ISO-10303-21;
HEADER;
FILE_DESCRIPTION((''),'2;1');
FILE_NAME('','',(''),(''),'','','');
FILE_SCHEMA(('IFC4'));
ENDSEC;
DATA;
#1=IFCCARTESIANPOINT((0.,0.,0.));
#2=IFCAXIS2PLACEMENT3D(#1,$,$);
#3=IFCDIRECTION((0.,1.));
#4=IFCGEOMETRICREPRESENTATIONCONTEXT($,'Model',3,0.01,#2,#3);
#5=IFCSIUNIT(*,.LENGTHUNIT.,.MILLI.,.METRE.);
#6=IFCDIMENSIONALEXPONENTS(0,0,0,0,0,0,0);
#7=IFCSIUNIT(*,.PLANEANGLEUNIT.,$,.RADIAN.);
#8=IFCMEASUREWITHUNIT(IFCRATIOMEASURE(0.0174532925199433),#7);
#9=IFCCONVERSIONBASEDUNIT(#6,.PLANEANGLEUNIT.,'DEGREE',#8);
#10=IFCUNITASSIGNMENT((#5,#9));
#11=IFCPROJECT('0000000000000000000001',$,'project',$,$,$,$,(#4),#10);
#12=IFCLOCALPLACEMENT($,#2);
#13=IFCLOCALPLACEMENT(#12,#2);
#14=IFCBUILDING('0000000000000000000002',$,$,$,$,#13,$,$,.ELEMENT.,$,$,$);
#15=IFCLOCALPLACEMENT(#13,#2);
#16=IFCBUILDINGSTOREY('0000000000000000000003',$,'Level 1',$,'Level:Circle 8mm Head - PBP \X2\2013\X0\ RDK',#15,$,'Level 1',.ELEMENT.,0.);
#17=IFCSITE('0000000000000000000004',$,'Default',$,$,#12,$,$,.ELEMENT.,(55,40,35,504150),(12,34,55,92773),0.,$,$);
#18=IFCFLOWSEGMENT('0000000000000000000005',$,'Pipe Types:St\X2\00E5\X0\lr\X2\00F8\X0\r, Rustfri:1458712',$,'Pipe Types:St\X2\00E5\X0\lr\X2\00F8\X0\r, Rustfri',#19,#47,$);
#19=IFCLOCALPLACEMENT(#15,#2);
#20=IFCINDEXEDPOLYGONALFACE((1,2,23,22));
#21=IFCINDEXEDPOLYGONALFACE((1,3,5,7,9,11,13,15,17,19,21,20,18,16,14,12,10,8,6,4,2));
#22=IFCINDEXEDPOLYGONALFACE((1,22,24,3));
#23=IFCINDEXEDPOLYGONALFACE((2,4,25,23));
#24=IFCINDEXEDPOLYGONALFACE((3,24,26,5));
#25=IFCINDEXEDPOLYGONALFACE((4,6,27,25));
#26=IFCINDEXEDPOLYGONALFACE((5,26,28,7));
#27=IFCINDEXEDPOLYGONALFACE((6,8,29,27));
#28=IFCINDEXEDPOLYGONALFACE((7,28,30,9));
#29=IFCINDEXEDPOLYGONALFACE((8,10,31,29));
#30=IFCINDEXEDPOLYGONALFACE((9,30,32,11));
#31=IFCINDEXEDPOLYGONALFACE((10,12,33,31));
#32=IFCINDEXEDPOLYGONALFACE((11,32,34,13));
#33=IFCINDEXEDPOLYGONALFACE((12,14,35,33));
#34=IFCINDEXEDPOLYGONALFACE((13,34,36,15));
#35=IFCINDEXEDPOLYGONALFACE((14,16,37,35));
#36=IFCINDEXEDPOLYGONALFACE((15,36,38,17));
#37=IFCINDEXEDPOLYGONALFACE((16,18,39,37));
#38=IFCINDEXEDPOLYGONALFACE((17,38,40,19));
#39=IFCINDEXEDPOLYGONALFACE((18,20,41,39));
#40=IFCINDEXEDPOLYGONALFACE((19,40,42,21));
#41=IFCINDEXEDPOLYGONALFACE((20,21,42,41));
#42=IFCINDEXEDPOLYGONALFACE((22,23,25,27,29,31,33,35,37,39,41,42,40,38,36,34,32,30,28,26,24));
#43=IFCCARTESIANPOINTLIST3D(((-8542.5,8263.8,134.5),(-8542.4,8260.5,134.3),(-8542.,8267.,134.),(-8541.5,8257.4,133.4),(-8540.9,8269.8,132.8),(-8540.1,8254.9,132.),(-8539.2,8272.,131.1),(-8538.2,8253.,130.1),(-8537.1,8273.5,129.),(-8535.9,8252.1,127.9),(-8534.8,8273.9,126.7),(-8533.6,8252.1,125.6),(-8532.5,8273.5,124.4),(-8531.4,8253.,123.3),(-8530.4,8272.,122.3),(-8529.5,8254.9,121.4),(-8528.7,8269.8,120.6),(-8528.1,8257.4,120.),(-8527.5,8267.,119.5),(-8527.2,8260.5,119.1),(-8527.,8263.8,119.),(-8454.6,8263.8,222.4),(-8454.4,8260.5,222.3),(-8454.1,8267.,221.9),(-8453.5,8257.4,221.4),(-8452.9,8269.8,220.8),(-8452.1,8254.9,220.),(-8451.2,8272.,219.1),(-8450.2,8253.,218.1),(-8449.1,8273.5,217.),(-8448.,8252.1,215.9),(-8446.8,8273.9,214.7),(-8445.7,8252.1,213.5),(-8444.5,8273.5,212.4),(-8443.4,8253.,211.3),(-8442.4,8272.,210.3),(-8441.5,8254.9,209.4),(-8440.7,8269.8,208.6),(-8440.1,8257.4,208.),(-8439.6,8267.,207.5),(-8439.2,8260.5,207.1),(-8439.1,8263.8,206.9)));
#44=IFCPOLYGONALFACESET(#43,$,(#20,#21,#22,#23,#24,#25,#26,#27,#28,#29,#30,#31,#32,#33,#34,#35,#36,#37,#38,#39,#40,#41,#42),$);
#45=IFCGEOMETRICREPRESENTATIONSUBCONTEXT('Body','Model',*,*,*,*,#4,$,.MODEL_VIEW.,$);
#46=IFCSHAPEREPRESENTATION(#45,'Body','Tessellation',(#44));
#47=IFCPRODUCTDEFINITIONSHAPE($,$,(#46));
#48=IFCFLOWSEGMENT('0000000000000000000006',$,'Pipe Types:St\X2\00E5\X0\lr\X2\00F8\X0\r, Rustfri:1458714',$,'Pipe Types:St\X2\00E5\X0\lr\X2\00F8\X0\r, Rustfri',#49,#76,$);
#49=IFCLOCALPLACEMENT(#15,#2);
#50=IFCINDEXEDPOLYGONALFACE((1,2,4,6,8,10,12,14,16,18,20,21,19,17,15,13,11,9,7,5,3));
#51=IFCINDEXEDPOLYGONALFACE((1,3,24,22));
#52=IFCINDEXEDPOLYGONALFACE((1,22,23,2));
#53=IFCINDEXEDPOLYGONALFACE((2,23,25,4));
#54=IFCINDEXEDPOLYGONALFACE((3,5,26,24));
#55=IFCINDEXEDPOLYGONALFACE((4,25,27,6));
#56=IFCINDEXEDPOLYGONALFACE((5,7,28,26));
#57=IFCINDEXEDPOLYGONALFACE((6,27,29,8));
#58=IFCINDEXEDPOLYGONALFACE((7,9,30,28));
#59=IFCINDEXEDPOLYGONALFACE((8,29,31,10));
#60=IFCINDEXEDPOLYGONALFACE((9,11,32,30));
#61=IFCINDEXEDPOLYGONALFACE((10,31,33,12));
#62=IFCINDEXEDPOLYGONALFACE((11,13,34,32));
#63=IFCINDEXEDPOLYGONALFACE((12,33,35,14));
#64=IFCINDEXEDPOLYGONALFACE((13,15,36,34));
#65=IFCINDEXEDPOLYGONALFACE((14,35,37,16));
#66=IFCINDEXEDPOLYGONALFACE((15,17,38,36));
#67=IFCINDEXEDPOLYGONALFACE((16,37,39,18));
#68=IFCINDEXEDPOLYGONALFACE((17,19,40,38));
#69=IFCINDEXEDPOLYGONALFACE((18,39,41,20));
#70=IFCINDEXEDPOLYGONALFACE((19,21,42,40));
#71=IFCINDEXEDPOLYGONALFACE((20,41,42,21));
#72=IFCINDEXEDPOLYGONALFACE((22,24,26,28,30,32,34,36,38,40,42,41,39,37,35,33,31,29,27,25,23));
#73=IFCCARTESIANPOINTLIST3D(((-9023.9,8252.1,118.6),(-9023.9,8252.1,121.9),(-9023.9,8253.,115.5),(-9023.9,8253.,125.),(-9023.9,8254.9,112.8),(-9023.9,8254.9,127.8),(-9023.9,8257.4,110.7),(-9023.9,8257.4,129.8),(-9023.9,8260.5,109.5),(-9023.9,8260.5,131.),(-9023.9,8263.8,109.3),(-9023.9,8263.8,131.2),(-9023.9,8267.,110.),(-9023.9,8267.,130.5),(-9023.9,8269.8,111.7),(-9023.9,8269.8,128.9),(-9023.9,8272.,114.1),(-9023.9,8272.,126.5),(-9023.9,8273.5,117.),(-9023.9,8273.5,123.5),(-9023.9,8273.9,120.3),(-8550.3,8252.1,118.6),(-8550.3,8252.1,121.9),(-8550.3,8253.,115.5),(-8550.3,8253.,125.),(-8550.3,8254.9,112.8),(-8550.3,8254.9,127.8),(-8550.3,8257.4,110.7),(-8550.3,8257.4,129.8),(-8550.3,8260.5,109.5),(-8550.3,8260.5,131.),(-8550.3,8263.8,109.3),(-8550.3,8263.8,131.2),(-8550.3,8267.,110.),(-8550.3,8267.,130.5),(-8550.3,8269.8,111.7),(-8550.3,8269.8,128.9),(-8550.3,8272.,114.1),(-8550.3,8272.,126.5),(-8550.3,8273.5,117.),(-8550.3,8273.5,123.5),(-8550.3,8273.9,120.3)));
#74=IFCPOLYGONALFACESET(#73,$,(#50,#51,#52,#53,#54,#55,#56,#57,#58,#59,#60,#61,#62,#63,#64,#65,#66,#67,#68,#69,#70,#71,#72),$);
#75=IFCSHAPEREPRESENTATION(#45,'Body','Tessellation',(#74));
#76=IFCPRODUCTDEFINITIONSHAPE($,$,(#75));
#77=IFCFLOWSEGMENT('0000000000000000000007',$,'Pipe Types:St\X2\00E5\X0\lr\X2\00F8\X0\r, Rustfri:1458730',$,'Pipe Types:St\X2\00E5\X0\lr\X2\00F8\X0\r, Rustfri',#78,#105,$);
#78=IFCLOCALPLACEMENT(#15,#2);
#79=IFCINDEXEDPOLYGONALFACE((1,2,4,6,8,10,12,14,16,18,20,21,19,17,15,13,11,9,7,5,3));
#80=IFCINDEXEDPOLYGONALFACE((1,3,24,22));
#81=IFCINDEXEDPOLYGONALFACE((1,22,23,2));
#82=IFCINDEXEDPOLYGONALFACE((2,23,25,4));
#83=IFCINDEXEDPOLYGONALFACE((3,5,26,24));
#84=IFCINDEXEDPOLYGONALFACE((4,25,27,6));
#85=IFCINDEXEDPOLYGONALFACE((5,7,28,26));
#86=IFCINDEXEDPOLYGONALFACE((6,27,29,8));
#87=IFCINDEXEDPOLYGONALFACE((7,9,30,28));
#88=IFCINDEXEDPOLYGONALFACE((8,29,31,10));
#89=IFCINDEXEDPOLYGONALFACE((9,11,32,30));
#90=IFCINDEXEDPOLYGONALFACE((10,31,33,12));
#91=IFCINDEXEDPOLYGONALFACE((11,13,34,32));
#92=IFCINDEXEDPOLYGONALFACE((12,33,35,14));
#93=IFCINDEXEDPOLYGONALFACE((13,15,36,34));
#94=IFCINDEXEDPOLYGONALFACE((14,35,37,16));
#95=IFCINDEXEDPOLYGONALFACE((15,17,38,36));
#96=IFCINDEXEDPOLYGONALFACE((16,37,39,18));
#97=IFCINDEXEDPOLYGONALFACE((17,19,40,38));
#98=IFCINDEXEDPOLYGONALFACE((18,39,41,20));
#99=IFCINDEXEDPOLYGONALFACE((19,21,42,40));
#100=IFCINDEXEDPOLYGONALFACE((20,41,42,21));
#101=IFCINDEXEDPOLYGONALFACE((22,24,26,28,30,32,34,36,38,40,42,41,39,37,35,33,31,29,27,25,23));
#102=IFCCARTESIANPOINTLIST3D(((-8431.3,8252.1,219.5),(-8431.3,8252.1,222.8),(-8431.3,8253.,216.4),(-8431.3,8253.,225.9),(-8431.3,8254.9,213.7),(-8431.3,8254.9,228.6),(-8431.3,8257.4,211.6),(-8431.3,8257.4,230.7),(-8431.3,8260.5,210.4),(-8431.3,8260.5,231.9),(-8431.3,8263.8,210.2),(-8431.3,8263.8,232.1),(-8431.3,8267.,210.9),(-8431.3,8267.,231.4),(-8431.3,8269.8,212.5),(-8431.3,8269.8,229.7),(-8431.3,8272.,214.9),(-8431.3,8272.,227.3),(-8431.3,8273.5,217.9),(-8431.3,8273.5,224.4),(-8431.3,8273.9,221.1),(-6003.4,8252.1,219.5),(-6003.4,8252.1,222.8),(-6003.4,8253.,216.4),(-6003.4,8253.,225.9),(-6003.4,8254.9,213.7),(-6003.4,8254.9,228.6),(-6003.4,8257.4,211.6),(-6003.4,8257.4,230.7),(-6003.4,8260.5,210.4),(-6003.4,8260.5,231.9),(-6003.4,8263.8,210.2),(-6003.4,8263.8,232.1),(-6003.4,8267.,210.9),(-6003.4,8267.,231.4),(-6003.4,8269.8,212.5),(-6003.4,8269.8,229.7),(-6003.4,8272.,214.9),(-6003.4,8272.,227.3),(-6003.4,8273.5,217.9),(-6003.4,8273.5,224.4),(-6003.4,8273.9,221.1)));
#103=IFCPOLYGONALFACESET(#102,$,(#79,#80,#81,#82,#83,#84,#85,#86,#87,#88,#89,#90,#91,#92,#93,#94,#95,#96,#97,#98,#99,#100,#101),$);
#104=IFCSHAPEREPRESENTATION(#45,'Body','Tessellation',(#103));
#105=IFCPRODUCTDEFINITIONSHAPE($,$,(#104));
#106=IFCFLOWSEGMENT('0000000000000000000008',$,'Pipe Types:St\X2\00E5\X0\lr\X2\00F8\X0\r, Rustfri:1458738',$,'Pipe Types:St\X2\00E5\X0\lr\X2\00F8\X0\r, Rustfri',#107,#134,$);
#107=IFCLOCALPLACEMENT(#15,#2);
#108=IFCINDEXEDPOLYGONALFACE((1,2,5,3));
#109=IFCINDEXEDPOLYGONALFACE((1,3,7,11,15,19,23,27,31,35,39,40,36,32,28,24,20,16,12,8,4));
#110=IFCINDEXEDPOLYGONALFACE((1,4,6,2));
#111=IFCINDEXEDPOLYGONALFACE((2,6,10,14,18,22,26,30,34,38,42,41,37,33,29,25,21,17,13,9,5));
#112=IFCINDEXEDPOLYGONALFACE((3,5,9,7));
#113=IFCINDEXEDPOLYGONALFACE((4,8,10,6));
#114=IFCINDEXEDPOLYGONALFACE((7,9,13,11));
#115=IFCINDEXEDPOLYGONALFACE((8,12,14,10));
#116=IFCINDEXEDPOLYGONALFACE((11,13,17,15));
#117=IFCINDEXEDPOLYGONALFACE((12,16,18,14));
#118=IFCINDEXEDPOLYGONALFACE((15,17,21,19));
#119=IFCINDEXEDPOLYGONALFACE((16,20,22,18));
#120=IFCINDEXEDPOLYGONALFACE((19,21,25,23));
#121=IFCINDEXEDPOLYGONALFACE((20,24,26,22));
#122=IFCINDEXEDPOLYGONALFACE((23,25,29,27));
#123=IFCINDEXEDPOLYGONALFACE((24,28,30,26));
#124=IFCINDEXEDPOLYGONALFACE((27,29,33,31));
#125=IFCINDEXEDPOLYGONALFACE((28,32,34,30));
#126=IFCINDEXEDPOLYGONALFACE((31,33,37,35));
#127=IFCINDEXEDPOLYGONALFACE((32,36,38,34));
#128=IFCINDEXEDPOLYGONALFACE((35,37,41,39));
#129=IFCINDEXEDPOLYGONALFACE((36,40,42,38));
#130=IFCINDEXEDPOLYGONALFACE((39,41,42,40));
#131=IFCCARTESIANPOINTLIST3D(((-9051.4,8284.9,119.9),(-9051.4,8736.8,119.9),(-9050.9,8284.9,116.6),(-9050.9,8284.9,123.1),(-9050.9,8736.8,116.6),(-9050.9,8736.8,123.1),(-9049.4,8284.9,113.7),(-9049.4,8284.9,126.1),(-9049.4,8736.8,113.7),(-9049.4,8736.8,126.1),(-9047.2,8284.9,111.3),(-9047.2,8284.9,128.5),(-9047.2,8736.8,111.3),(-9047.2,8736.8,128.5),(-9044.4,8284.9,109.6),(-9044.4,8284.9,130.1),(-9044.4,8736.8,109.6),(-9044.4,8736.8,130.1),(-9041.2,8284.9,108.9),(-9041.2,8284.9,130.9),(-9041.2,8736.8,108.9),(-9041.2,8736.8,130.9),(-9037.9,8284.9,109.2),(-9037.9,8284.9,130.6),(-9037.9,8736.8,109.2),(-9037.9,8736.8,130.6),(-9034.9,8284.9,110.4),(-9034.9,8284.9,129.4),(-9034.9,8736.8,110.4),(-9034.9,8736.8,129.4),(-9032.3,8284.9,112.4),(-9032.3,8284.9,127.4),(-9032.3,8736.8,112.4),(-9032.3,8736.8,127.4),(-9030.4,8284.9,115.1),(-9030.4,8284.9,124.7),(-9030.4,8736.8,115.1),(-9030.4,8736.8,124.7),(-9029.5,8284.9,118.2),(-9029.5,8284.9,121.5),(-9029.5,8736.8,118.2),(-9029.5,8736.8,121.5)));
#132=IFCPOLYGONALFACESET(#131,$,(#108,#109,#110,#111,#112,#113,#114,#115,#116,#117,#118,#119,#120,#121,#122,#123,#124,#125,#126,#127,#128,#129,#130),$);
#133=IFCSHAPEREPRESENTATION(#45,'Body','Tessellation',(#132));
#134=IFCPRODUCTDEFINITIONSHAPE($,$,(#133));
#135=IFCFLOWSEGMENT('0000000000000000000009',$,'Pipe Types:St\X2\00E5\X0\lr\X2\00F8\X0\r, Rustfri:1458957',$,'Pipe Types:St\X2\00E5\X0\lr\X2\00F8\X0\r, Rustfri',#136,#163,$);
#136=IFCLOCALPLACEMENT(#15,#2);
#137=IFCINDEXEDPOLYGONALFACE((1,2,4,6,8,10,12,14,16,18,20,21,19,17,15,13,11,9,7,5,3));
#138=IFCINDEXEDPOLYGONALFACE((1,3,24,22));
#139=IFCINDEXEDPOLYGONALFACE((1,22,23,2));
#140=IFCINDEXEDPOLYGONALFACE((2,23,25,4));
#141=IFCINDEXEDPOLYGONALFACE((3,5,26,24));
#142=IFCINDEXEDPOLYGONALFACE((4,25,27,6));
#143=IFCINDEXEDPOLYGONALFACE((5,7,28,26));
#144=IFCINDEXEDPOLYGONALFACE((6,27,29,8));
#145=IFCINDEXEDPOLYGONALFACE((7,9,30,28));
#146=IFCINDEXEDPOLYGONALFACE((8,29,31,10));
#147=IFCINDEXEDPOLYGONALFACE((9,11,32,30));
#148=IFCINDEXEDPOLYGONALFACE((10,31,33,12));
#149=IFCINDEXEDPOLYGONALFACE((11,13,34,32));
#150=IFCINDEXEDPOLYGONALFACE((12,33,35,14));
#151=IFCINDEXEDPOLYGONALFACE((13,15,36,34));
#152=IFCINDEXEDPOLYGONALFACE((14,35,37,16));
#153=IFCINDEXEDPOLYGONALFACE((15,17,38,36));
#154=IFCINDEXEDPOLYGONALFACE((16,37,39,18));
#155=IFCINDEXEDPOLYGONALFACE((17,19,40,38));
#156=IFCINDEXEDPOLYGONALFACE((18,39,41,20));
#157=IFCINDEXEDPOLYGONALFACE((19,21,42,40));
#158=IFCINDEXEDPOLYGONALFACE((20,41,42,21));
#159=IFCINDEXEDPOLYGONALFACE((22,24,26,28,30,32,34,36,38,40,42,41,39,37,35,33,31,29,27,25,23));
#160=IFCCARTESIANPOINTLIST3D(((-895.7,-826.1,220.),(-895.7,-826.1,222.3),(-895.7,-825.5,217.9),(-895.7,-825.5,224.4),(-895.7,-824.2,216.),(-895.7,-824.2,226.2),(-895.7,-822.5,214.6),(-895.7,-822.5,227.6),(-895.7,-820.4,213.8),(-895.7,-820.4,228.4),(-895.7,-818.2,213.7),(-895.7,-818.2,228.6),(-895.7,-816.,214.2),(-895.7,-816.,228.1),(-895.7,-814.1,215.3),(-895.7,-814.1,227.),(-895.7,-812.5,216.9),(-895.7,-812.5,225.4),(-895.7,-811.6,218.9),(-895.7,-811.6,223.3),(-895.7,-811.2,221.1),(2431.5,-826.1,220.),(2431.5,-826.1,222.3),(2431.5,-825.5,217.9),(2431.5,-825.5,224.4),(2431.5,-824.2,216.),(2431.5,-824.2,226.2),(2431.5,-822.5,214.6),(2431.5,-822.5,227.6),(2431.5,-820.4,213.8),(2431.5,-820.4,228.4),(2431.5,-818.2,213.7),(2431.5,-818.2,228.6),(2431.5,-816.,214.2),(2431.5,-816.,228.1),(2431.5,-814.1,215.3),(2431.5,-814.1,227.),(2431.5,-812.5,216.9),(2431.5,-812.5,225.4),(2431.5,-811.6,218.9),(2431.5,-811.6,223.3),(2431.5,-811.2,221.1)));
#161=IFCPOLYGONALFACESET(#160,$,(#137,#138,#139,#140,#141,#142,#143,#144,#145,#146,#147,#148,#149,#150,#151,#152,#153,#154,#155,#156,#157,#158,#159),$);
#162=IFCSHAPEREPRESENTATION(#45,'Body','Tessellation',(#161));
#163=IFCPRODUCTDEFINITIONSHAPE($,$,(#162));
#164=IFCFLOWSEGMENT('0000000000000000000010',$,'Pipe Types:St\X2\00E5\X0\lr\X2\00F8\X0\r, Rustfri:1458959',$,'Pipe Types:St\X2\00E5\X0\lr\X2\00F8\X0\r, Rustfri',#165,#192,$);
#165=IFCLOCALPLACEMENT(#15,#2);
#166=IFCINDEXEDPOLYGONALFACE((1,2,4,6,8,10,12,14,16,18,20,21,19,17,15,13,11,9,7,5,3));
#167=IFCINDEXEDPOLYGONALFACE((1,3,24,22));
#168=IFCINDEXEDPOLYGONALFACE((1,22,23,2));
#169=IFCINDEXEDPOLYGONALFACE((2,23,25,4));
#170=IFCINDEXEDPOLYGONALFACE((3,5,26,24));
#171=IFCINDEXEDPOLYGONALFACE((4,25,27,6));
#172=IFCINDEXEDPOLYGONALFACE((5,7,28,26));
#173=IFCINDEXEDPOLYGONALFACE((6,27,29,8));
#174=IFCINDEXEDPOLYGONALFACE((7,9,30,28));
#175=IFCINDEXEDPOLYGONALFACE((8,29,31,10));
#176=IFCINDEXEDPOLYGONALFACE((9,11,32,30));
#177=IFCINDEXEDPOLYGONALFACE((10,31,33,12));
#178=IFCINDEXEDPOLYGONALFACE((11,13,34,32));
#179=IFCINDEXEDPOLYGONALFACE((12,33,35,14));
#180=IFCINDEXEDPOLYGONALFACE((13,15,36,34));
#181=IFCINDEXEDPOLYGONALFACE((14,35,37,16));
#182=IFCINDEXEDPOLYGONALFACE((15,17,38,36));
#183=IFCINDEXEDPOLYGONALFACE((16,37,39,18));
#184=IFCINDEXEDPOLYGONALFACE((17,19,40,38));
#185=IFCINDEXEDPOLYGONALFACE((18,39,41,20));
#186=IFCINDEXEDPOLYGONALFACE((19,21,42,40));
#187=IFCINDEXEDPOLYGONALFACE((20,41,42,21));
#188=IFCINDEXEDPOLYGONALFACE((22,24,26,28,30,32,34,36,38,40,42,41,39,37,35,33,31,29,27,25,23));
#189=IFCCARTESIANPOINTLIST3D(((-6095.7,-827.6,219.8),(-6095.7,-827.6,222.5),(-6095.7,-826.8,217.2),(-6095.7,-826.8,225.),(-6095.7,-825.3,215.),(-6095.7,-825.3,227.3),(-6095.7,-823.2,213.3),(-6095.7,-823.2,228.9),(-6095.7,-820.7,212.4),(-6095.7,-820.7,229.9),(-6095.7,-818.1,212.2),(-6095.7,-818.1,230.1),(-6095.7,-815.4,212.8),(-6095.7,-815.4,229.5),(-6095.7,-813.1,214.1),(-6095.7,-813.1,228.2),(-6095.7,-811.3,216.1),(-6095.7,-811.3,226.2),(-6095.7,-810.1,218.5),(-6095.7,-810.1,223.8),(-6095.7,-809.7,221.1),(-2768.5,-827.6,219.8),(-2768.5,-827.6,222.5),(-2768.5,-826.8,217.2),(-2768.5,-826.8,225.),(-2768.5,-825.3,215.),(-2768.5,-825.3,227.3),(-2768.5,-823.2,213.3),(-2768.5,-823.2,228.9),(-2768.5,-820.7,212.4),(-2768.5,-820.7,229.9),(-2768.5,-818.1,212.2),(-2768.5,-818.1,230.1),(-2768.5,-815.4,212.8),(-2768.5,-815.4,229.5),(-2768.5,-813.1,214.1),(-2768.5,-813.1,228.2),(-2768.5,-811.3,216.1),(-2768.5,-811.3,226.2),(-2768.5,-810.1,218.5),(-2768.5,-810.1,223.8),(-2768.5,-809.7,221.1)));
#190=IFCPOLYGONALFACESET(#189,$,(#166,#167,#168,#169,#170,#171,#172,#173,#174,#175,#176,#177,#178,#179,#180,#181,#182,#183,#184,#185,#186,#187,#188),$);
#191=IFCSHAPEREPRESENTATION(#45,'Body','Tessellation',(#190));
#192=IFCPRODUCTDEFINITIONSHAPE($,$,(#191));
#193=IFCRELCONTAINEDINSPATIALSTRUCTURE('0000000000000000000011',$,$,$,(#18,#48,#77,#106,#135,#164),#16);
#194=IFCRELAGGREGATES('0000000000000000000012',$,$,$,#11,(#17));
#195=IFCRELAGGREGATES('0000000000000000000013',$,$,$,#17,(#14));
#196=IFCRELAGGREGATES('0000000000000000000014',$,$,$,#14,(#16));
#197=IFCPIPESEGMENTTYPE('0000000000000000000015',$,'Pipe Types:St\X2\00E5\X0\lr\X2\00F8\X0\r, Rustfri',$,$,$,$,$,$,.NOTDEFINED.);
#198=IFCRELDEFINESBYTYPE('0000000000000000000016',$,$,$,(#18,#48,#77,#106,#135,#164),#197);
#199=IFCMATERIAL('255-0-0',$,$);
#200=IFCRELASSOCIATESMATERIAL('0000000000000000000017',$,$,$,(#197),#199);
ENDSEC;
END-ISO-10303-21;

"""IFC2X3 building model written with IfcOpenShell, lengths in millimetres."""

from ifc_helpers import new_model, entity, si_unit, converted_unit, direction, frame, frame_2d, origin, origin_2d_with_axis, place, context, subcontext, project, spatial, circle, extrude, material, type_object, element, save


model = new_model("IFC2X3")

# Units and contexts
model_context = context("Model", 3, precision=0.01, world=origin(), true_north=direction((0.0, 1.0)))
body_context = subcontext(model_context, "Body", "Model", "MODEL_VIEW")
ifc_project = project(units=[si_unit("LENGTHUNIT", "METRE", prefix="MILLI"), converted_unit("PLANEANGLEUNIT", "DEGREE", entity("IfcRatioMeasure", 0.0174532925199433), si_unit("PLANEANGLEUNIT", "RADIAN"), dimensions=[0, 0, 0, 0, 0, 0, 0])], contexts=[model_context])

# Site, building, storey
site_placement = place(None, origin())
site = spatial("IfcSite", under=ifc_project, at=site_placement, Name="Default", CompositionType="ELEMENT", RefLatitude=(55, 40, 35, 504150), RefLongitude=(12, 34, 55, 92773), RefElevation=0.0)
building_placement = place(site_placement, origin())
building = spatial("IfcBuilding", under=site, at=building_placement, CompositionType="ELEMENT")
storey_placement = place(building_placement, origin())
storey = spatial("IfcBuildingStorey", under=building, at=storey_placement, Name="Level 1", ObjectType="Level:Circle 8mm Head - PBP – RDK", LongName="Level 1", CompositionType="ELEMENT", Elevation=0.0)

# Shared definitions
ifc_material_1 = material(Name="255-0-0")

# Flow segments
pipe_segment_type = type_object("IfcPipeSegmentType", Name="Pipe Types:Stålrør, Rustfri", PredefinedType="NOTDEFINED", material=ifc_material_1)
flow_segment_1_placement = place(storey_placement, origin())
element("IfcFlowSegment", 1, at=flow_segment_1_placement, inside=storey, type_object=pipe_segment_type, Name="Pipe Types:Stålrør, Rustfri:1458712", ObjectType="Pipe Types:Stålrør, Rustfri", context=body_context, shape_type="SweptSolid", body=[
    extrude(circle(Radius=11.0, at=frame_2d((0.0, 0.0), x_axis=(1.0, 0.0))), frame((-8534.8, 8262.9, 126.7), z_axis=(0.707107, -0.000017, 0.707107), x_axis=(0.000024, 1.0, 0.0)), (0.0, 0.0, 1.0), 124.4),
])
flow_segment_2_placement = place(storey_placement, origin())
element("IfcFlowSegment", 2, at=flow_segment_2_placement, inside=storey, type_object=pipe_segment_type, Name="Pipe Types:Stålrør, Rustfri:1458714", ObjectType="Pipe Types:Stålrør, Rustfri", context=body_context, shape_type="SweptSolid", body=[
    extrude(circle(Radius=11.0, at=frame_2d((0.0, 0.0), x_axis=(1.0, 0.0))), frame((-9023.9, 8262.9, 120.3), z_axis=(1.0, 0.0, 0.0), x_axis=(0.0, 1.0, 0.0)), (0.0, 0.0, 1.0), 473.5),
])
flow_segment_3_placement = place(storey_placement, origin())
element("IfcFlowSegment", 3, at=flow_segment_3_placement, inside=storey, type_object=pipe_segment_type, Name="Pipe Types:Stålrør, Rustfri:1458730", ObjectType="Pipe Types:Stålrør, Rustfri", context=body_context, shape_type="SweptSolid", body=[
    extrude(circle(Radius=11.0, at=frame_2d((0.0, 0.0), x_axis=(1.0, 0.0))), frame((-8431.3, 8262.9, 221.1), z_axis=(1.0, 0.0, 0.0), x_axis=(0.0, 1.0, 0.0)), (0.0, 0.0, 1.0), 2427.9),
])
flow_segment_4_placement = place(storey_placement, origin())
element("IfcFlowSegment", 4, at=flow_segment_4_placement, inside=storey, type_object=pipe_segment_type, Name="Pipe Types:Stålrør, Rustfri:1458738", ObjectType="Pipe Types:Stålrør, Rustfri", context=body_context, shape_type="SweptSolid", body=[
    extrude(circle(Radius=11.0, at=origin_2d_with_axis()), frame((-9040.4, 8284.9, 119.9), z_axis=(0.0, 1.0, 0.0), x_axis=(-1.0, 0.0, 0.0)), (0.0, 0.0, 1.0), 451.8),
])
flow_segment_5_placement = place(storey_placement, origin())
element("IfcFlowSegment", 5, at=flow_segment_5_placement, inside=storey, type_object=pipe_segment_type, Name="Pipe Types:Stålrør, Rustfri:1458957", ObjectType="Pipe Types:Stålrør, Rustfri", context=body_context, shape_type="SweptSolid", body=[
    extrude(circle(Radius=7.5, at=frame_2d((0.0, 0.0), x_axis=(1.0, 0.0))), frame((-895.7, -818.7, 221.1), z_axis=(1.0, 0.0, 0.0), x_axis=(0.0, 1.0, 0.0)), (0.0, 0.0, 1.0), 3327.2),
])
flow_segment_6_placement = place(storey_placement, origin())
element("IfcFlowSegment", 6, at=flow_segment_6_placement, inside=storey, type_object=pipe_segment_type, Name="Pipe Types:Stålrør, Rustfri:1458959", ObjectType="Pipe Types:Stålrør, Rustfri", context=body_context, shape_type="SweptSolid", body=[
    extrude(circle(Radius=9.0, at=frame_2d((0.0, 0.0), x_axis=(1.0, 0.0))), frame((-6095.7, -818.7, 221.1), z_axis=(1.0, 0.0, 0.0), x_axis=(0.0, 1.0, 0.0)), (0.0, 0.0, 1.0), 3327.2),
])

save(model, "model.ifc")
